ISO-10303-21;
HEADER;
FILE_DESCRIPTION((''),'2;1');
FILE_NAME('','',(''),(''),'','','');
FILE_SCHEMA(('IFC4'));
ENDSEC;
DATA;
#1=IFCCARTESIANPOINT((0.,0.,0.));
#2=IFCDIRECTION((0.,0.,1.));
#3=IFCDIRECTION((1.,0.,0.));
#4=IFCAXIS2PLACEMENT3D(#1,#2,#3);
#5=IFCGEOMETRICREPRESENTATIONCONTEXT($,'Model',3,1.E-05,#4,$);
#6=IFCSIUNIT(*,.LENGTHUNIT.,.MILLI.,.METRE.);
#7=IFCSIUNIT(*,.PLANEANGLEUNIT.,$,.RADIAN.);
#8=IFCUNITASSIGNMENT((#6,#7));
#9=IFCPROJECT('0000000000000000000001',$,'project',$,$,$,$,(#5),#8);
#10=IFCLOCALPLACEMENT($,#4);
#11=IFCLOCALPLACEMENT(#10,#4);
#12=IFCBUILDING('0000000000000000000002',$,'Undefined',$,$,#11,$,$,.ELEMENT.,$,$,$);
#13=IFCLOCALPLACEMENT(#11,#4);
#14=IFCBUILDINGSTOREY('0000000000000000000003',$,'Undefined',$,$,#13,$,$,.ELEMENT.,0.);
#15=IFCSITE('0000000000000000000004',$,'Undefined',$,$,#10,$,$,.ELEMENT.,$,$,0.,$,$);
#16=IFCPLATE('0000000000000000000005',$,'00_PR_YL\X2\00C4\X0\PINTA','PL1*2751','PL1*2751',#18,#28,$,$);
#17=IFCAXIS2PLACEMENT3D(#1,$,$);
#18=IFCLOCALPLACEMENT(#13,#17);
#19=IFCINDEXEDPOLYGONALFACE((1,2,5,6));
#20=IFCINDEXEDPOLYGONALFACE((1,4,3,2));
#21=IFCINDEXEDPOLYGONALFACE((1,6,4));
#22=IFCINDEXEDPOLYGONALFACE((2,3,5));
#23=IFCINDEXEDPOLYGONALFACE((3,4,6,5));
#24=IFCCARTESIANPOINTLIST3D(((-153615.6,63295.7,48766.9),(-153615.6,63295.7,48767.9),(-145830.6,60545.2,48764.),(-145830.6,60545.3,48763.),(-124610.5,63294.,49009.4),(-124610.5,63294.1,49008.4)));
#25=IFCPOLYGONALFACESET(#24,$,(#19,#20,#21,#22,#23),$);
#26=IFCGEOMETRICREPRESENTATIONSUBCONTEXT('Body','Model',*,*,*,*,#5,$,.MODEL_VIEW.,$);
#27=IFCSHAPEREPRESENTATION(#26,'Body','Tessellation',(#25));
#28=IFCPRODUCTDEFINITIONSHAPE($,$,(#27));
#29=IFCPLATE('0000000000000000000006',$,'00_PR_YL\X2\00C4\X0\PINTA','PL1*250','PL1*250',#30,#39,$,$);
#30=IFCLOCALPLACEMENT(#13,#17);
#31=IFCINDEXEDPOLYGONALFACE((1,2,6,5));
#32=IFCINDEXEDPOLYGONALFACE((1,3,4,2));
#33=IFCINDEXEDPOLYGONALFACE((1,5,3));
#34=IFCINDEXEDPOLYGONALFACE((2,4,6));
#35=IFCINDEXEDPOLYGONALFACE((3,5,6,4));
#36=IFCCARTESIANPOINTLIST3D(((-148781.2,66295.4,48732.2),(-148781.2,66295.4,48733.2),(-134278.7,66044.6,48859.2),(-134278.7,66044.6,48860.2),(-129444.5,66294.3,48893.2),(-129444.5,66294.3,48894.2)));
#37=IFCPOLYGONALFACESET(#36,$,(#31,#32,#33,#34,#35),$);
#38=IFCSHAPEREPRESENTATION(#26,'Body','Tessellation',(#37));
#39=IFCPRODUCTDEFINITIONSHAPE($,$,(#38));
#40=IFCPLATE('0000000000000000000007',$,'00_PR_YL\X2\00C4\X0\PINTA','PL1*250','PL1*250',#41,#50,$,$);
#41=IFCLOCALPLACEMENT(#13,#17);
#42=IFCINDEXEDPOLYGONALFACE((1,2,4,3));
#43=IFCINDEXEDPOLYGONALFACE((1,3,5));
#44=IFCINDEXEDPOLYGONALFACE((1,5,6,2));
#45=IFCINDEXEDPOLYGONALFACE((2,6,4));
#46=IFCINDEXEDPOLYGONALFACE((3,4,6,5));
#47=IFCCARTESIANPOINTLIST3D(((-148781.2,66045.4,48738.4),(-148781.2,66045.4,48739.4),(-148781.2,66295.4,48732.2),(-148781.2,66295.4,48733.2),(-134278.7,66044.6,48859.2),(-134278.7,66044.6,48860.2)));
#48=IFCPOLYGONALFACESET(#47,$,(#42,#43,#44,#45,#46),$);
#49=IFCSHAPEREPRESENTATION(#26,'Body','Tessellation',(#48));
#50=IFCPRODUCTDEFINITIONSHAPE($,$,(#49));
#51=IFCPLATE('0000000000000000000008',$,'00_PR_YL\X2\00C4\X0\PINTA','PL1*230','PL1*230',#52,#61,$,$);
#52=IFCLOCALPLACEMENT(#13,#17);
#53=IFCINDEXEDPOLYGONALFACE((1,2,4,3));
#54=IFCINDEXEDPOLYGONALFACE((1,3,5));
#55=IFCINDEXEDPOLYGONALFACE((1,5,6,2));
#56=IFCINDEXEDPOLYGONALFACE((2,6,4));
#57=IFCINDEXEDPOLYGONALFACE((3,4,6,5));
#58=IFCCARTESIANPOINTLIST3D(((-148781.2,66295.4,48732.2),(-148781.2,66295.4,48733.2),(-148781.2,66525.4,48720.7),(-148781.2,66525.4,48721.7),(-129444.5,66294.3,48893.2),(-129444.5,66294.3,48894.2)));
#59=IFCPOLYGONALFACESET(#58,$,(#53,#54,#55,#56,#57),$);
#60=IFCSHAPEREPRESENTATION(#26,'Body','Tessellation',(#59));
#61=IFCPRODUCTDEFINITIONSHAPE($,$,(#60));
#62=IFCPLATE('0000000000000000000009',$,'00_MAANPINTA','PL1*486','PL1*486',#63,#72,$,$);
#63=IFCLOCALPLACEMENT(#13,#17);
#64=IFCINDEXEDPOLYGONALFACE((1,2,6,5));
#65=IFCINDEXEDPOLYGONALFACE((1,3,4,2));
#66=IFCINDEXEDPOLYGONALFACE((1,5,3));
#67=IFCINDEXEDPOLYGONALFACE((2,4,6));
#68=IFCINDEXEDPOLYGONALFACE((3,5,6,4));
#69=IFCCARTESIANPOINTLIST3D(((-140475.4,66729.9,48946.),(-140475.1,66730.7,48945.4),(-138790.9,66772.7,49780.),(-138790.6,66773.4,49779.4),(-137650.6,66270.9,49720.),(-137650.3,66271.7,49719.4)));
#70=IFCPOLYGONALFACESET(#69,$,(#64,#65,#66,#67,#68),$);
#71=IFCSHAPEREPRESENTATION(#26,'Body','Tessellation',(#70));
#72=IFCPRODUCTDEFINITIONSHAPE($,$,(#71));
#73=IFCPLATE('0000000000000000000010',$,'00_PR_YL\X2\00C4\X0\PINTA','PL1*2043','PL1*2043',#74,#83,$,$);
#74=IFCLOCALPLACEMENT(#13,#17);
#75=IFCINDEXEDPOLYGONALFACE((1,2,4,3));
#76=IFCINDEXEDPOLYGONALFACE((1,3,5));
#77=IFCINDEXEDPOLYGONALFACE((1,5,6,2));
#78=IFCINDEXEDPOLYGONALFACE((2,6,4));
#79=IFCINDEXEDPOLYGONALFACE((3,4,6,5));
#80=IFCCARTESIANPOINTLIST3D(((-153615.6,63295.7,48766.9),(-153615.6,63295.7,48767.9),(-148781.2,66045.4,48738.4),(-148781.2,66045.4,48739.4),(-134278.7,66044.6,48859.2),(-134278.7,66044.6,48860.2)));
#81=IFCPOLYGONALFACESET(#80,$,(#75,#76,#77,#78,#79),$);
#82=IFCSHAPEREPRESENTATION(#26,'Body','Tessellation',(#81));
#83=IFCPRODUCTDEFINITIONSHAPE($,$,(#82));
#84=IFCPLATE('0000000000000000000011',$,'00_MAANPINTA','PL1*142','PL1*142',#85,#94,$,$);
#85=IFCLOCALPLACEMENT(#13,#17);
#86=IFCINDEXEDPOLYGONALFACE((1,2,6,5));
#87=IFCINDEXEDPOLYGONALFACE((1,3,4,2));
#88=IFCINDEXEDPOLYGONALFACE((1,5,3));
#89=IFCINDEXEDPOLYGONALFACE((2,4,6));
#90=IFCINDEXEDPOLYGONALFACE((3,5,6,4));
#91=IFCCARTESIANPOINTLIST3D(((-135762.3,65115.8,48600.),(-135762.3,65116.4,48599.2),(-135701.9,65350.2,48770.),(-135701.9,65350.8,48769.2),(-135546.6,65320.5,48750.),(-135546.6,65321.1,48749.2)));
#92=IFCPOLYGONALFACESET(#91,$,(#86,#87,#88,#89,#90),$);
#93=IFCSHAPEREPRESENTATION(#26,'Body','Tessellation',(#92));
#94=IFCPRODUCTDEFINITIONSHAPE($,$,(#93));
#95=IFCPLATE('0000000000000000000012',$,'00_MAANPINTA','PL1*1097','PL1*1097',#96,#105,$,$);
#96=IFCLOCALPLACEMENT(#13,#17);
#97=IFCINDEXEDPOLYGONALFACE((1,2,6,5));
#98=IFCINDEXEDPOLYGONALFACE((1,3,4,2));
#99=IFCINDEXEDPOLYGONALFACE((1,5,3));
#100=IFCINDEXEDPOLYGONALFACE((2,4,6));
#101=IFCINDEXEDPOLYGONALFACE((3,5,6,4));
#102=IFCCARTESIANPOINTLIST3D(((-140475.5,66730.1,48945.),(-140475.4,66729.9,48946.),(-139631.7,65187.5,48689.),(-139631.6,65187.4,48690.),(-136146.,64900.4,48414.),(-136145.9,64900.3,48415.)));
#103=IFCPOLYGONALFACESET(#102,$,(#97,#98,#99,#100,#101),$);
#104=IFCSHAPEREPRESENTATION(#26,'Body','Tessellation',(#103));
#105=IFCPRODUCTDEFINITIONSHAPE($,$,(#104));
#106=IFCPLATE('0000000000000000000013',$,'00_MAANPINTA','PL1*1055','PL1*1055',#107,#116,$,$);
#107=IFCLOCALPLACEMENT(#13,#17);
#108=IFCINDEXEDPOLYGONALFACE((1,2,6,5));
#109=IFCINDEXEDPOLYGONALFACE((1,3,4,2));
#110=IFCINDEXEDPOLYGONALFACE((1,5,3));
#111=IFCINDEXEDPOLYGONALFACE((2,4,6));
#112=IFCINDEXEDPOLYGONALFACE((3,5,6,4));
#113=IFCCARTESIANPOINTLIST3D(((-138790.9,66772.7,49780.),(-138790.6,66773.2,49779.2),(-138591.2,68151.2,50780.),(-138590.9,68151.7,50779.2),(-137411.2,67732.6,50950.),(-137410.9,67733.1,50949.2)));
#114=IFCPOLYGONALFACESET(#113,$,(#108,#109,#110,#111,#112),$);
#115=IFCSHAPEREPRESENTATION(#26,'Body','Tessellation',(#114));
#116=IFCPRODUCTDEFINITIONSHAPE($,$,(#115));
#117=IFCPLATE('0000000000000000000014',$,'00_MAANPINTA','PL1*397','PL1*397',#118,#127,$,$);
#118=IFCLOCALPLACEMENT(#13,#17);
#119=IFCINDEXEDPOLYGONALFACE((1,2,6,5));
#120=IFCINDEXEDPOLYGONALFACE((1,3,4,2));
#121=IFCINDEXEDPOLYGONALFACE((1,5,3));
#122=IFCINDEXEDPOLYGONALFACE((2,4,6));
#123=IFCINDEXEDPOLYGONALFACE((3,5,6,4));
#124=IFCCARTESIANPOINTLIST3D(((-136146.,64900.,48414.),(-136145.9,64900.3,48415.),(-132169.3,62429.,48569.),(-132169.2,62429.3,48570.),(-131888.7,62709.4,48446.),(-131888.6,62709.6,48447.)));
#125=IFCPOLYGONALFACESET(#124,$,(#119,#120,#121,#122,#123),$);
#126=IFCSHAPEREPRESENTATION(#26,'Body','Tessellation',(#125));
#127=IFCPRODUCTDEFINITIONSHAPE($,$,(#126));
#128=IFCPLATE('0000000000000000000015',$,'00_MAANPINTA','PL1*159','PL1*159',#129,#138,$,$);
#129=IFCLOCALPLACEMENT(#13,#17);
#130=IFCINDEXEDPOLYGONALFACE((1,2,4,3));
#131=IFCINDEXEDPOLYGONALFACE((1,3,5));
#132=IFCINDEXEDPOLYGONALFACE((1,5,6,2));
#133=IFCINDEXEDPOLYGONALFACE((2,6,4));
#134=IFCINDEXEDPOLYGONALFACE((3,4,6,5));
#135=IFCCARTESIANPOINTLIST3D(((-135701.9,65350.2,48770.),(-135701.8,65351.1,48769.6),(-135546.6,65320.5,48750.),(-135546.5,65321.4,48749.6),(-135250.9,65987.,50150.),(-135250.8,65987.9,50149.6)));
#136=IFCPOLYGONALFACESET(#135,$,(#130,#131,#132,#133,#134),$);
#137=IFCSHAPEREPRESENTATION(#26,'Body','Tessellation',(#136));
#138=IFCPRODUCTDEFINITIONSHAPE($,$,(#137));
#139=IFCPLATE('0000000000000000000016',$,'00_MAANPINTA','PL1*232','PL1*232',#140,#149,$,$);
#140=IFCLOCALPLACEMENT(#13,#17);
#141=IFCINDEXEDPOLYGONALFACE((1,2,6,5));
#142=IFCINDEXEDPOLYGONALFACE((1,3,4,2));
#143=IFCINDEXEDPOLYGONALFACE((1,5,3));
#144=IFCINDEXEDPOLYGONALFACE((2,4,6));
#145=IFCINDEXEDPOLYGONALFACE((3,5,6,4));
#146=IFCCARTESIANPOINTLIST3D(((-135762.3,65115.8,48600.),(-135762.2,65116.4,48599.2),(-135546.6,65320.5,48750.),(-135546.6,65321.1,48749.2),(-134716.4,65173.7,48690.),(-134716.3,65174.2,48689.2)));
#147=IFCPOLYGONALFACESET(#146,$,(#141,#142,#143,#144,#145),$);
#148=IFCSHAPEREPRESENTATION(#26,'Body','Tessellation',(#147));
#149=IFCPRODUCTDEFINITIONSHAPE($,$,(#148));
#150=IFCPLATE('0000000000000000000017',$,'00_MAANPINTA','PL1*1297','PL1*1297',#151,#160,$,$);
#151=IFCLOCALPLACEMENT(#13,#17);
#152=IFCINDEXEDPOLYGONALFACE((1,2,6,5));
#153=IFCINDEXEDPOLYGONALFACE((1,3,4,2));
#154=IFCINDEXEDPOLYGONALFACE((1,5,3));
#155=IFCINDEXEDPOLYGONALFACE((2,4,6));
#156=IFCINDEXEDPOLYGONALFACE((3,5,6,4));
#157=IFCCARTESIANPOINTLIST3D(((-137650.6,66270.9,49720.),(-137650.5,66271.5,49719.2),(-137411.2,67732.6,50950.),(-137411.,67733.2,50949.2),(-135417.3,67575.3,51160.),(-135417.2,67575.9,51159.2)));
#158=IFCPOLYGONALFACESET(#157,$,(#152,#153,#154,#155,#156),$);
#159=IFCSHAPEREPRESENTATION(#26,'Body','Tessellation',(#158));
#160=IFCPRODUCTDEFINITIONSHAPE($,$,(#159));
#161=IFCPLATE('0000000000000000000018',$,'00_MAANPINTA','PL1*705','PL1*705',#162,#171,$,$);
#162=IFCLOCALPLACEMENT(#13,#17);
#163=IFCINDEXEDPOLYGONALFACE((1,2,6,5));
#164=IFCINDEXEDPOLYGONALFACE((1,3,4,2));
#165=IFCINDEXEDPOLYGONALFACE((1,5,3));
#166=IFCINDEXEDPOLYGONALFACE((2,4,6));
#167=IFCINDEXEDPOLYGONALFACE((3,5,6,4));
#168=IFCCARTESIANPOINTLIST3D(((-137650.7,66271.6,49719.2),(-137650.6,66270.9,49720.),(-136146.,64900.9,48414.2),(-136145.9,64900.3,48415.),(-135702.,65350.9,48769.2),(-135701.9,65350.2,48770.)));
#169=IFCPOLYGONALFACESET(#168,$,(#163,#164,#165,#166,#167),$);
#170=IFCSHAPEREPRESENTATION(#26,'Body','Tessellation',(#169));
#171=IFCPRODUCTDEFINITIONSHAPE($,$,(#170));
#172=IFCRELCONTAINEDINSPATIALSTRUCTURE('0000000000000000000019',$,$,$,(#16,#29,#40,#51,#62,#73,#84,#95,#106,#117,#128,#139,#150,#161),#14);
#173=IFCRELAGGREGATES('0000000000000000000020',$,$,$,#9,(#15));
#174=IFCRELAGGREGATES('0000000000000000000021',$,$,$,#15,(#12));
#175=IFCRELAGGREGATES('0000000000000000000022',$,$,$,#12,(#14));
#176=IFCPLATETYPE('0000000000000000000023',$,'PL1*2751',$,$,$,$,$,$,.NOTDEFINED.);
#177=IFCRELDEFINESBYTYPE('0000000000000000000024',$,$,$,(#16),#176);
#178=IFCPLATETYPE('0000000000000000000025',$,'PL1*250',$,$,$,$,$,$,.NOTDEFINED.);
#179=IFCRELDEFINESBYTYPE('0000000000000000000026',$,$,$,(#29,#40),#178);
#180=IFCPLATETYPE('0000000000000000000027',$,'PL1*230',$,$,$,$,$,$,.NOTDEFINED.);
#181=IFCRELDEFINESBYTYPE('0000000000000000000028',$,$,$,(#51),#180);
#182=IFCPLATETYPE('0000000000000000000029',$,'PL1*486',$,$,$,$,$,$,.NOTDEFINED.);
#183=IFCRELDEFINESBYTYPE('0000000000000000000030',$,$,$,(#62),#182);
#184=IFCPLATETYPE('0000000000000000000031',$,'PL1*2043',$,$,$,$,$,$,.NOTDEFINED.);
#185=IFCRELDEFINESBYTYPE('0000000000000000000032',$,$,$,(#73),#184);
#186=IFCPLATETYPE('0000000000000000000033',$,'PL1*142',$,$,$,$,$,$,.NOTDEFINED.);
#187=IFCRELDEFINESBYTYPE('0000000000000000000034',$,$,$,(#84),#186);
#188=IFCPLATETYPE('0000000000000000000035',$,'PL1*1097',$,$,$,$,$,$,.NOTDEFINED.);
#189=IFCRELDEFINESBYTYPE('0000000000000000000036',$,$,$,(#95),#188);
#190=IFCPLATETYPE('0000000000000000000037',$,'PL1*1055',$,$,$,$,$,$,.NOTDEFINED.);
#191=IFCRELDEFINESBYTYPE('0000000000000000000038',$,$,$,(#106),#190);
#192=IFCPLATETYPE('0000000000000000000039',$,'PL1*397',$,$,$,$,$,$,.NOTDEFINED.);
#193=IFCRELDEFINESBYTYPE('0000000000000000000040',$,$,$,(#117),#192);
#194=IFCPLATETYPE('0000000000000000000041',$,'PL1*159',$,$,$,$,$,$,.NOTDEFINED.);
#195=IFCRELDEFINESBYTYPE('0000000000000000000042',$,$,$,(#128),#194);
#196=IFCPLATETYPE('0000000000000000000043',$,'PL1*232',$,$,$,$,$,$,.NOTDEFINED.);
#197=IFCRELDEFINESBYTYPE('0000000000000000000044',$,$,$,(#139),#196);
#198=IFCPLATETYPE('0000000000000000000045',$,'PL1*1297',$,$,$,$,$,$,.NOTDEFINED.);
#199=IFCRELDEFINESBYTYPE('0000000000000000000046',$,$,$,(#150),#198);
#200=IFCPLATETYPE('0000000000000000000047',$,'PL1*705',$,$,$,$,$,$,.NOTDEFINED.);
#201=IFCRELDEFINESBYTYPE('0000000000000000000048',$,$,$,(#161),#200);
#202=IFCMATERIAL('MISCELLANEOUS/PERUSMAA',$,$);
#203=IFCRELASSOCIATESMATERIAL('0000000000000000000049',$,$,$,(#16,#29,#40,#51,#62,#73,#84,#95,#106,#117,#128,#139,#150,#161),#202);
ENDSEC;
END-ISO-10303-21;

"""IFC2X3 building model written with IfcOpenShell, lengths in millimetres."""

from ifc_helpers import new_model, si_unit, frame, origin_with_axes, place, context, subcontext, project, spatial, polyline, outline, extrude, material, type_object, element, save


model = new_model("IFC2X3")

# Units and contexts
model_context = context("Model", 3, precision=1e-05, world=origin_with_axes())
body_context = subcontext(model_context, "Body", "Model", "MODEL_VIEW")
ifc_project = project(units=[si_unit("LENGTHUNIT", "METRE", prefix="MILLI"), si_unit("PLANEANGLEUNIT", "RADIAN")], contexts=[model_context])

# Site, building, storey
site_placement = place(None, origin_with_axes())
site = spatial("IfcSite", under=ifc_project, at=site_placement, Name="Undefined", CompositionType="ELEMENT", RefElevation=0.0)
building_placement = place(site_placement, origin_with_axes())
building = spatial("IfcBuilding", under=site, at=building_placement, Name="Undefined", CompositionType="ELEMENT")
storey_placement = place(building_placement, origin_with_axes())
storey = spatial("IfcBuildingStorey", under=building, at=storey_placement, Name="Undefined", CompositionType="ELEMENT", Elevation=0.0)

# Plates
ifc_material = material(Name="MISCELLANEOUS/PERUSMAA")
plate_type_1 = type_object("IfcPlateType", Name="PL1*2751", PredefinedType="NOTDEFINED")
for number, where, z_axis, x_axis, name in (
    (1, (-153615.6, 63295.7, 48767.4), (0.008324, 0.024991, -0.999653), (0.999965, -0.000057, 0.008325), "00_PR_YLÄPINTA"),
):
    element("IfcPlate", number, at=place(storey_placement, frame(where, z_axis=z_axis, x_axis=x_axis)), inside=storey, type_object=plate_type_1, material=ifc_material, Name=name, Description="PL1*2751", ObjectType="PL1*2751", context=body_context, shape_type="SweptSolid", body=[
        extrude(outline(polyline([(0.0, 0.0), (29006.1, 0.0), (7784.8, 2750.9), (0.0, 0.0)])), frame((0.0, 0.0, -0.5), z_axis=(0.0, 0.0, 1.0), x_axis=(1.0, 0.0, 0.0)), (0.0, 0.0, 1.0), 1.0),
    ])
plate_type_2 = type_object("IfcPlateType", Name="PL1*250", PredefinedType="NOTDEFINED")
plate_1_placement = place(storey_placement, frame((-148781.2, 66295.4, 48732.7), z_axis=(0.008321, -0.024992, -0.999653), x_axis=(0.999965, -0.000057, 0.008325)))
element("IfcPlate", 2, at=plate_1_placement, inside=storey, type_object=plate_type_2, material=ifc_material, Name="00_PR_YLÄPINTA", Description="PL1*250", ObjectType="PL1*250", context=body_context, shape_type="SweptSolid", body=[
    extrude(outline(polyline([(0.0, 0.0), (19337.4, 0.0), (14503.1, 250.1), (0.0, 0.0)])), frame((0.0, 0.0, -0.5), z_axis=(0.0, 0.0, 1.0), x_axis=(1.0, 0.0, 0.0)), (0.0, 0.0, 1.0), 1.0),
])
plate_2_placement = place(storey_placement, frame((-148781.2, 66045.4, 48738.9), z_axis=(0.008321, -0.024992, -0.999653), x_axis=(0.000057, 0.999688, -0.024992)))
element("IfcPlate", 3, at=plate_2_placement, inside=storey, type_object=plate_type_2, material=ifc_material, Name="00_PR_YLÄPINTA", Description="PL1*250", ObjectType="PL1*250", context=body_context, shape_type="SweptSolid", body=[
    extrude(outline(polyline([(0.0, 0.0), (250.1, 0.0), (-3.0, 14503.0), (0.0, 0.0)])), frame((0.0, 0.0, -0.5), z_axis=(0.0, 0.0, 1.0), x_axis=(1.0, 0.0, 0.0)), (0.0, 0.0, 1.0), 1.0),
])
plate_type_3 = type_object("IfcPlateType", Name="PL1*230", PredefinedType="NOTDEFINED")
for number, where, z_axis, x_axis, name in (
    (4, (-148781.2, 66525.4, 48721.2), (0.008312, -0.049936, -0.998718), (0.999889, -0.01195, 0.008919), "00_PR_YLÄPINTA"),
):
    element("IfcPlate", number, at=place(storey_placement, frame(where, z_axis=z_axis, x_axis=x_axis)), inside=storey, type_object=plate_type_3, material=ifc_material, Name=name, Description="PL1*230", ObjectType="PL1*230", context=body_context, shape_type="SweptSolid", body=[
        extrude(outline(polyline([(0.0, 0.0), (19338.8, 0.0), (2.8, 230.3), (0.0, 0.0)])), frame((0.0, 0.0, -0.5), z_axis=(0.0, 0.0, 1.0), x_axis=(1.0, 0.0, 0.0)), (0.0, 0.0, 1.0), 1.0),
    ])
plate_type_4 = type_object("IfcPlateType", Name="PL1*486", PredefinedType="NOTDEFINED")
plate_3_placement = place(storey_placement, frame((-137650.5, 66271.3, 49719.7), z_axis=(0.288448, 0.72961, -0.620053), x_axis=(-0.952822, 0.154823, -0.261074)))
element("IfcPlate", 5, at=plate_3_placement, inside=storey, type_object=plate_type_4, material=ifc_material, Name="00_MAANPINTA", Description="PL1*486", ObjectType="PL1*486", context=body_context, shape_type="SweptSolid", body=[
    extrude(outline(polyline([(0.0, 0.0), (2964.7, 0.0), (1148.5, 486.4), (0.0, 0.0)])), frame((0.0, 0.0, -0.5), z_axis=(0.0, 0.0, 1.0), x_axis=(1.0, 0.0, 0.0)), (0.0, 0.0, 1.0), 1.0),
])
plate_type_5 = type_object("IfcPlateType", Name="PL1*2043", PredefinedType="NOTDEFINED")
for number, where, z_axis, x_axis, name in (
    (6, (-148781.2, 66045.4, 48738.9), (0.008321, -0.024992, -0.999653), (0.999965, -0.000057, 0.008325), "00_PR_YLÄPINTA"),
):
    element("IfcPlate", number, at=place(storey_placement, frame(where, z_axis=z_axis, x_axis=x_axis)), inside=storey, type_object=plate_type_5, material=ifc_material, Name=name, Description="PL1*2043", ObjectType="PL1*2043", context=body_context, shape_type="SweptSolid", body=[
        extrude(outline(polyline([(0.0, 0.0), (14503.0, 0.0), (-4833.8, 2750.9), (0.0, 0.0)])), frame((0.0, 0.0, -0.5), z_axis=(0.0, 0.0, 1.0), x_axis=(1.0, 0.0, 0.0)), (0.0, 0.0, 1.0), 1.0),
    ])
plate_type_6 = type_object("IfcPlateType", Name="PL1*142", PredefinedType="NOTDEFINED")
plate_4_placement = place(storey_placement, frame((-135701.9, 65350.5, 48769.6), z_axis=(0.007828, 0.585719, -0.810476), x_axis=(0.974375, -0.186668, -0.125491)))
element("IfcPlate", 7, at=plate_4_placement, inside=storey, type_object=plate_type_6, material=ifc_material, Name="00_MAANPINTA", Description="PL1*142", ObjectType="PL1*142", context=body_context, shape_type="SweptSolid", body=[
    extrude(outline(polyline([(0.0, 0.0), (159.4, 0.0), (6.3, 295.7), (0.0, 0.0)])), frame((0.0, 0.0, -0.5), z_axis=(0.0, 0.0, 1.0), x_axis=(1.0, 0.0, 0.0)), (0.0, 0.0, 1.0), 1.0),
])
plate_type_7 = type_object("IfcPlateType", Name="PL1*1097", PredefinedType="NOTDEFINED")
plate_5_placement = place(storey_placement, frame((-140475.4, 66730.0, 48945.5), z_axis=(-0.067589, 0.127256, -0.989564), x_axis=(0.915304, -0.386803, -0.112259)))
element("IfcPlate", 8, at=plate_5_placement, inside=storey, type_object=plate_type_7, material=ifc_material, Name="00_MAANPINTA", Description="PL1*1097", ObjectType="PL1*1097", context=body_context, shape_type="SweptSolid", body=[
    extrude(outline(polyline([(0.0, 0.0), (4730.1, 0.0), (1397.7, 1097.0), (0.0, 0.0)])), frame((0.0, 0.0, -0.5), z_axis=(0.0, 0.0, 1.0), x_axis=(1.0, 0.0, 0.0)), (0.0, 0.0, 1.0), 1.0),
])
plate_type_8 = type_object("IfcPlateType", Name="PL1*1055", PredefinedType="NOTDEFINED")
plate_6_placement = place(storey_placement, frame((-138790.7, 66773.0, 49779.6), z_axis=(0.302321, 0.530649, -0.791842), x_axis=(0.116458, 0.803929, 0.583212)))
element("IfcPlate", 9, at=plate_6_placement, inside=storey, type_object=plate_type_8, material=ifc_material, Name="00_MAANPINTA", Description="PL1*1055", ObjectType="PL1*1055", context=body_context, shape_type="SweptSolid", body=[
    extrude(outline(polyline([(0.0, 0.0), (1714.6, 0.0), (1614.7, 1259.6), (0.0, 0.0)])), frame((0.0, 0.0, -0.5), z_axis=(0.0, 0.0, 1.0), x_axis=(1.0, 0.0, 0.0)), (0.0, 0.0, 1.0), 1.0),
])
plate_type_9 = type_object("IfcPlateType", Name="PL1*397", PredefinedType="NOTDEFINED")
plate_7_placement = place(storey_placement, frame((-136146.0, 64900.2, 48414.5), z_axis=(-0.136869, -0.279873, -0.950231), x_axis=(0.889169, -0.457531, 0.006683)))
element("IfcPlate", 10, at=plate_7_placement, inside=storey, type_object=plate_type_9, material=ifc_material, Name="00_MAANPINTA", Description="PL1*397", ObjectType="PL1*397", context=body_context, shape_type="SweptSolid", body=[
    extrude(outline(polyline([(0.0, 0.0), (4788.0, 0.0), (4667.6, 397.5), (0.0, 0.0)])), frame((0.0, 0.0, -0.5), z_axis=(0.0, 0.0, 1.0), x_axis=(1.0, 0.0, 0.0)), (0.0, 0.0, 1.0), 1.0),
])
plate_type_10 = type_object("IfcPlateType", Name="PL1*159", PredefinedType="NOTDEFINED")
plate_8_placement = place(storey_placement, frame((-135546.6, 65320.9, 48749.8), z_axis=(0.112574, 0.887722, -0.446403), x_axis=(-0.974375, 0.186668, 0.125491)))
element("IfcPlate", 11, at=plate_8_placement, inside=storey, type_object=plate_type_10, material=ifc_material, Name="00_MAANPINTA", Description="PL1*159", ObjectType="PL1*159", context=body_context, shape_type="SweptSolid", body=[
    extrude(outline(polyline([(0.0, 0.0), (159.4, 0.0), (11.9, 1578.5), (0.0, 0.0)])), frame((0.0, 0.0, -0.5), z_axis=(0.0, 0.0, 1.0), x_axis=(1.0, 0.0, 0.0)), (0.0, 0.0, 1.0), 1.0),
])
plate_type_11 = type_object("IfcPlateType", Name="PL1*232", PredefinedType="NOTDEFINED")
plate_9_placement = place(storey_placement, frame((-135546.6, 65320.8, 48749.6), z_axis=(0.039897, 0.562958, -0.825522), x_axis=(0.982237, -0.173699, -0.070982)))
element("IfcPlate", 12, at=plate_9_placement, inside=storey, type_object=plate_type_11, material=ifc_material, Name="00_MAANPINTA", Description="PL1*232", ObjectType="PL1*232", context=body_context, shape_type="SweptSolid", body=[
    extrude(outline(polyline([(0.0, 0.0), (845.3, 0.0), (-165.6, 288.9), (0.0, 0.0)])), frame((0.0, 0.0, -0.5), z_axis=(0.0, 0.0, 1.0), x_axis=(1.0, 0.0, 0.0)), (0.0, 0.0, 1.0), 1.0),
])
plate_type_12 = type_object("IfcPlateType", Name="PL1*1297", PredefinedType="NOTDEFINED")
plate_10_placement = place(storey_placement, frame((-137650.5, 66271.2, 49719.6), z_axis=(0.130346, 0.625795, -0.769019), x_axis=(0.124371, 0.759189, 0.638877)))
element("IfcPlate", 13, at=plate_10_placement, inside=storey, type_object=plate_type_12, material=ifc_material, Name="00_MAANPINTA", Description="PL1*1297", ObjectType="PL1*1297", context=body_context, shape_type="SweptSolid", body=[
    extrude(outline(polyline([(0.0, 0.0), (1925.3, 0.0), (2188.0, 1993.8), (0.0, 0.0)])), frame((0.0, 0.0, -0.5), z_axis=(0.0, 0.0, 1.0), x_axis=(1.0, 0.0, 0.0)), (0.0, 0.0, 1.0), 1.0),
])
plate_type_13 = type_object("IfcPlateType", Name="PL1*705", PredefinedType="NOTDEFINED")
plate_11_placement = place(storey_placement, frame((-135702.0, 65350.6, 48769.6), z_axis=(-0.059047, 0.65359, -0.754542), x_axis=(-0.612407, -0.62063, -0.48967)))
element("IfcPlate", 14, at=plate_11_placement, inside=storey, type_object=plate_type_13, material=ifc_material, Name="00_MAANPINTA", Description="PL1*705", ObjectType="PL1*705", context=body_context, shape_type="SweptSolid", body=[
    extrude(outline(polyline([(0.0, 0.0), (725.0, 0.0), (156.8, 2350.1), (0.0, 0.0)])), frame((0.0, 0.0, -0.5), z_axis=(0.0, 0.0, 1.0), x_axis=(1.0, 0.0, 0.0)), (0.0, 0.0, 1.0), 1.0),
])

save(model, "model.ifc")
